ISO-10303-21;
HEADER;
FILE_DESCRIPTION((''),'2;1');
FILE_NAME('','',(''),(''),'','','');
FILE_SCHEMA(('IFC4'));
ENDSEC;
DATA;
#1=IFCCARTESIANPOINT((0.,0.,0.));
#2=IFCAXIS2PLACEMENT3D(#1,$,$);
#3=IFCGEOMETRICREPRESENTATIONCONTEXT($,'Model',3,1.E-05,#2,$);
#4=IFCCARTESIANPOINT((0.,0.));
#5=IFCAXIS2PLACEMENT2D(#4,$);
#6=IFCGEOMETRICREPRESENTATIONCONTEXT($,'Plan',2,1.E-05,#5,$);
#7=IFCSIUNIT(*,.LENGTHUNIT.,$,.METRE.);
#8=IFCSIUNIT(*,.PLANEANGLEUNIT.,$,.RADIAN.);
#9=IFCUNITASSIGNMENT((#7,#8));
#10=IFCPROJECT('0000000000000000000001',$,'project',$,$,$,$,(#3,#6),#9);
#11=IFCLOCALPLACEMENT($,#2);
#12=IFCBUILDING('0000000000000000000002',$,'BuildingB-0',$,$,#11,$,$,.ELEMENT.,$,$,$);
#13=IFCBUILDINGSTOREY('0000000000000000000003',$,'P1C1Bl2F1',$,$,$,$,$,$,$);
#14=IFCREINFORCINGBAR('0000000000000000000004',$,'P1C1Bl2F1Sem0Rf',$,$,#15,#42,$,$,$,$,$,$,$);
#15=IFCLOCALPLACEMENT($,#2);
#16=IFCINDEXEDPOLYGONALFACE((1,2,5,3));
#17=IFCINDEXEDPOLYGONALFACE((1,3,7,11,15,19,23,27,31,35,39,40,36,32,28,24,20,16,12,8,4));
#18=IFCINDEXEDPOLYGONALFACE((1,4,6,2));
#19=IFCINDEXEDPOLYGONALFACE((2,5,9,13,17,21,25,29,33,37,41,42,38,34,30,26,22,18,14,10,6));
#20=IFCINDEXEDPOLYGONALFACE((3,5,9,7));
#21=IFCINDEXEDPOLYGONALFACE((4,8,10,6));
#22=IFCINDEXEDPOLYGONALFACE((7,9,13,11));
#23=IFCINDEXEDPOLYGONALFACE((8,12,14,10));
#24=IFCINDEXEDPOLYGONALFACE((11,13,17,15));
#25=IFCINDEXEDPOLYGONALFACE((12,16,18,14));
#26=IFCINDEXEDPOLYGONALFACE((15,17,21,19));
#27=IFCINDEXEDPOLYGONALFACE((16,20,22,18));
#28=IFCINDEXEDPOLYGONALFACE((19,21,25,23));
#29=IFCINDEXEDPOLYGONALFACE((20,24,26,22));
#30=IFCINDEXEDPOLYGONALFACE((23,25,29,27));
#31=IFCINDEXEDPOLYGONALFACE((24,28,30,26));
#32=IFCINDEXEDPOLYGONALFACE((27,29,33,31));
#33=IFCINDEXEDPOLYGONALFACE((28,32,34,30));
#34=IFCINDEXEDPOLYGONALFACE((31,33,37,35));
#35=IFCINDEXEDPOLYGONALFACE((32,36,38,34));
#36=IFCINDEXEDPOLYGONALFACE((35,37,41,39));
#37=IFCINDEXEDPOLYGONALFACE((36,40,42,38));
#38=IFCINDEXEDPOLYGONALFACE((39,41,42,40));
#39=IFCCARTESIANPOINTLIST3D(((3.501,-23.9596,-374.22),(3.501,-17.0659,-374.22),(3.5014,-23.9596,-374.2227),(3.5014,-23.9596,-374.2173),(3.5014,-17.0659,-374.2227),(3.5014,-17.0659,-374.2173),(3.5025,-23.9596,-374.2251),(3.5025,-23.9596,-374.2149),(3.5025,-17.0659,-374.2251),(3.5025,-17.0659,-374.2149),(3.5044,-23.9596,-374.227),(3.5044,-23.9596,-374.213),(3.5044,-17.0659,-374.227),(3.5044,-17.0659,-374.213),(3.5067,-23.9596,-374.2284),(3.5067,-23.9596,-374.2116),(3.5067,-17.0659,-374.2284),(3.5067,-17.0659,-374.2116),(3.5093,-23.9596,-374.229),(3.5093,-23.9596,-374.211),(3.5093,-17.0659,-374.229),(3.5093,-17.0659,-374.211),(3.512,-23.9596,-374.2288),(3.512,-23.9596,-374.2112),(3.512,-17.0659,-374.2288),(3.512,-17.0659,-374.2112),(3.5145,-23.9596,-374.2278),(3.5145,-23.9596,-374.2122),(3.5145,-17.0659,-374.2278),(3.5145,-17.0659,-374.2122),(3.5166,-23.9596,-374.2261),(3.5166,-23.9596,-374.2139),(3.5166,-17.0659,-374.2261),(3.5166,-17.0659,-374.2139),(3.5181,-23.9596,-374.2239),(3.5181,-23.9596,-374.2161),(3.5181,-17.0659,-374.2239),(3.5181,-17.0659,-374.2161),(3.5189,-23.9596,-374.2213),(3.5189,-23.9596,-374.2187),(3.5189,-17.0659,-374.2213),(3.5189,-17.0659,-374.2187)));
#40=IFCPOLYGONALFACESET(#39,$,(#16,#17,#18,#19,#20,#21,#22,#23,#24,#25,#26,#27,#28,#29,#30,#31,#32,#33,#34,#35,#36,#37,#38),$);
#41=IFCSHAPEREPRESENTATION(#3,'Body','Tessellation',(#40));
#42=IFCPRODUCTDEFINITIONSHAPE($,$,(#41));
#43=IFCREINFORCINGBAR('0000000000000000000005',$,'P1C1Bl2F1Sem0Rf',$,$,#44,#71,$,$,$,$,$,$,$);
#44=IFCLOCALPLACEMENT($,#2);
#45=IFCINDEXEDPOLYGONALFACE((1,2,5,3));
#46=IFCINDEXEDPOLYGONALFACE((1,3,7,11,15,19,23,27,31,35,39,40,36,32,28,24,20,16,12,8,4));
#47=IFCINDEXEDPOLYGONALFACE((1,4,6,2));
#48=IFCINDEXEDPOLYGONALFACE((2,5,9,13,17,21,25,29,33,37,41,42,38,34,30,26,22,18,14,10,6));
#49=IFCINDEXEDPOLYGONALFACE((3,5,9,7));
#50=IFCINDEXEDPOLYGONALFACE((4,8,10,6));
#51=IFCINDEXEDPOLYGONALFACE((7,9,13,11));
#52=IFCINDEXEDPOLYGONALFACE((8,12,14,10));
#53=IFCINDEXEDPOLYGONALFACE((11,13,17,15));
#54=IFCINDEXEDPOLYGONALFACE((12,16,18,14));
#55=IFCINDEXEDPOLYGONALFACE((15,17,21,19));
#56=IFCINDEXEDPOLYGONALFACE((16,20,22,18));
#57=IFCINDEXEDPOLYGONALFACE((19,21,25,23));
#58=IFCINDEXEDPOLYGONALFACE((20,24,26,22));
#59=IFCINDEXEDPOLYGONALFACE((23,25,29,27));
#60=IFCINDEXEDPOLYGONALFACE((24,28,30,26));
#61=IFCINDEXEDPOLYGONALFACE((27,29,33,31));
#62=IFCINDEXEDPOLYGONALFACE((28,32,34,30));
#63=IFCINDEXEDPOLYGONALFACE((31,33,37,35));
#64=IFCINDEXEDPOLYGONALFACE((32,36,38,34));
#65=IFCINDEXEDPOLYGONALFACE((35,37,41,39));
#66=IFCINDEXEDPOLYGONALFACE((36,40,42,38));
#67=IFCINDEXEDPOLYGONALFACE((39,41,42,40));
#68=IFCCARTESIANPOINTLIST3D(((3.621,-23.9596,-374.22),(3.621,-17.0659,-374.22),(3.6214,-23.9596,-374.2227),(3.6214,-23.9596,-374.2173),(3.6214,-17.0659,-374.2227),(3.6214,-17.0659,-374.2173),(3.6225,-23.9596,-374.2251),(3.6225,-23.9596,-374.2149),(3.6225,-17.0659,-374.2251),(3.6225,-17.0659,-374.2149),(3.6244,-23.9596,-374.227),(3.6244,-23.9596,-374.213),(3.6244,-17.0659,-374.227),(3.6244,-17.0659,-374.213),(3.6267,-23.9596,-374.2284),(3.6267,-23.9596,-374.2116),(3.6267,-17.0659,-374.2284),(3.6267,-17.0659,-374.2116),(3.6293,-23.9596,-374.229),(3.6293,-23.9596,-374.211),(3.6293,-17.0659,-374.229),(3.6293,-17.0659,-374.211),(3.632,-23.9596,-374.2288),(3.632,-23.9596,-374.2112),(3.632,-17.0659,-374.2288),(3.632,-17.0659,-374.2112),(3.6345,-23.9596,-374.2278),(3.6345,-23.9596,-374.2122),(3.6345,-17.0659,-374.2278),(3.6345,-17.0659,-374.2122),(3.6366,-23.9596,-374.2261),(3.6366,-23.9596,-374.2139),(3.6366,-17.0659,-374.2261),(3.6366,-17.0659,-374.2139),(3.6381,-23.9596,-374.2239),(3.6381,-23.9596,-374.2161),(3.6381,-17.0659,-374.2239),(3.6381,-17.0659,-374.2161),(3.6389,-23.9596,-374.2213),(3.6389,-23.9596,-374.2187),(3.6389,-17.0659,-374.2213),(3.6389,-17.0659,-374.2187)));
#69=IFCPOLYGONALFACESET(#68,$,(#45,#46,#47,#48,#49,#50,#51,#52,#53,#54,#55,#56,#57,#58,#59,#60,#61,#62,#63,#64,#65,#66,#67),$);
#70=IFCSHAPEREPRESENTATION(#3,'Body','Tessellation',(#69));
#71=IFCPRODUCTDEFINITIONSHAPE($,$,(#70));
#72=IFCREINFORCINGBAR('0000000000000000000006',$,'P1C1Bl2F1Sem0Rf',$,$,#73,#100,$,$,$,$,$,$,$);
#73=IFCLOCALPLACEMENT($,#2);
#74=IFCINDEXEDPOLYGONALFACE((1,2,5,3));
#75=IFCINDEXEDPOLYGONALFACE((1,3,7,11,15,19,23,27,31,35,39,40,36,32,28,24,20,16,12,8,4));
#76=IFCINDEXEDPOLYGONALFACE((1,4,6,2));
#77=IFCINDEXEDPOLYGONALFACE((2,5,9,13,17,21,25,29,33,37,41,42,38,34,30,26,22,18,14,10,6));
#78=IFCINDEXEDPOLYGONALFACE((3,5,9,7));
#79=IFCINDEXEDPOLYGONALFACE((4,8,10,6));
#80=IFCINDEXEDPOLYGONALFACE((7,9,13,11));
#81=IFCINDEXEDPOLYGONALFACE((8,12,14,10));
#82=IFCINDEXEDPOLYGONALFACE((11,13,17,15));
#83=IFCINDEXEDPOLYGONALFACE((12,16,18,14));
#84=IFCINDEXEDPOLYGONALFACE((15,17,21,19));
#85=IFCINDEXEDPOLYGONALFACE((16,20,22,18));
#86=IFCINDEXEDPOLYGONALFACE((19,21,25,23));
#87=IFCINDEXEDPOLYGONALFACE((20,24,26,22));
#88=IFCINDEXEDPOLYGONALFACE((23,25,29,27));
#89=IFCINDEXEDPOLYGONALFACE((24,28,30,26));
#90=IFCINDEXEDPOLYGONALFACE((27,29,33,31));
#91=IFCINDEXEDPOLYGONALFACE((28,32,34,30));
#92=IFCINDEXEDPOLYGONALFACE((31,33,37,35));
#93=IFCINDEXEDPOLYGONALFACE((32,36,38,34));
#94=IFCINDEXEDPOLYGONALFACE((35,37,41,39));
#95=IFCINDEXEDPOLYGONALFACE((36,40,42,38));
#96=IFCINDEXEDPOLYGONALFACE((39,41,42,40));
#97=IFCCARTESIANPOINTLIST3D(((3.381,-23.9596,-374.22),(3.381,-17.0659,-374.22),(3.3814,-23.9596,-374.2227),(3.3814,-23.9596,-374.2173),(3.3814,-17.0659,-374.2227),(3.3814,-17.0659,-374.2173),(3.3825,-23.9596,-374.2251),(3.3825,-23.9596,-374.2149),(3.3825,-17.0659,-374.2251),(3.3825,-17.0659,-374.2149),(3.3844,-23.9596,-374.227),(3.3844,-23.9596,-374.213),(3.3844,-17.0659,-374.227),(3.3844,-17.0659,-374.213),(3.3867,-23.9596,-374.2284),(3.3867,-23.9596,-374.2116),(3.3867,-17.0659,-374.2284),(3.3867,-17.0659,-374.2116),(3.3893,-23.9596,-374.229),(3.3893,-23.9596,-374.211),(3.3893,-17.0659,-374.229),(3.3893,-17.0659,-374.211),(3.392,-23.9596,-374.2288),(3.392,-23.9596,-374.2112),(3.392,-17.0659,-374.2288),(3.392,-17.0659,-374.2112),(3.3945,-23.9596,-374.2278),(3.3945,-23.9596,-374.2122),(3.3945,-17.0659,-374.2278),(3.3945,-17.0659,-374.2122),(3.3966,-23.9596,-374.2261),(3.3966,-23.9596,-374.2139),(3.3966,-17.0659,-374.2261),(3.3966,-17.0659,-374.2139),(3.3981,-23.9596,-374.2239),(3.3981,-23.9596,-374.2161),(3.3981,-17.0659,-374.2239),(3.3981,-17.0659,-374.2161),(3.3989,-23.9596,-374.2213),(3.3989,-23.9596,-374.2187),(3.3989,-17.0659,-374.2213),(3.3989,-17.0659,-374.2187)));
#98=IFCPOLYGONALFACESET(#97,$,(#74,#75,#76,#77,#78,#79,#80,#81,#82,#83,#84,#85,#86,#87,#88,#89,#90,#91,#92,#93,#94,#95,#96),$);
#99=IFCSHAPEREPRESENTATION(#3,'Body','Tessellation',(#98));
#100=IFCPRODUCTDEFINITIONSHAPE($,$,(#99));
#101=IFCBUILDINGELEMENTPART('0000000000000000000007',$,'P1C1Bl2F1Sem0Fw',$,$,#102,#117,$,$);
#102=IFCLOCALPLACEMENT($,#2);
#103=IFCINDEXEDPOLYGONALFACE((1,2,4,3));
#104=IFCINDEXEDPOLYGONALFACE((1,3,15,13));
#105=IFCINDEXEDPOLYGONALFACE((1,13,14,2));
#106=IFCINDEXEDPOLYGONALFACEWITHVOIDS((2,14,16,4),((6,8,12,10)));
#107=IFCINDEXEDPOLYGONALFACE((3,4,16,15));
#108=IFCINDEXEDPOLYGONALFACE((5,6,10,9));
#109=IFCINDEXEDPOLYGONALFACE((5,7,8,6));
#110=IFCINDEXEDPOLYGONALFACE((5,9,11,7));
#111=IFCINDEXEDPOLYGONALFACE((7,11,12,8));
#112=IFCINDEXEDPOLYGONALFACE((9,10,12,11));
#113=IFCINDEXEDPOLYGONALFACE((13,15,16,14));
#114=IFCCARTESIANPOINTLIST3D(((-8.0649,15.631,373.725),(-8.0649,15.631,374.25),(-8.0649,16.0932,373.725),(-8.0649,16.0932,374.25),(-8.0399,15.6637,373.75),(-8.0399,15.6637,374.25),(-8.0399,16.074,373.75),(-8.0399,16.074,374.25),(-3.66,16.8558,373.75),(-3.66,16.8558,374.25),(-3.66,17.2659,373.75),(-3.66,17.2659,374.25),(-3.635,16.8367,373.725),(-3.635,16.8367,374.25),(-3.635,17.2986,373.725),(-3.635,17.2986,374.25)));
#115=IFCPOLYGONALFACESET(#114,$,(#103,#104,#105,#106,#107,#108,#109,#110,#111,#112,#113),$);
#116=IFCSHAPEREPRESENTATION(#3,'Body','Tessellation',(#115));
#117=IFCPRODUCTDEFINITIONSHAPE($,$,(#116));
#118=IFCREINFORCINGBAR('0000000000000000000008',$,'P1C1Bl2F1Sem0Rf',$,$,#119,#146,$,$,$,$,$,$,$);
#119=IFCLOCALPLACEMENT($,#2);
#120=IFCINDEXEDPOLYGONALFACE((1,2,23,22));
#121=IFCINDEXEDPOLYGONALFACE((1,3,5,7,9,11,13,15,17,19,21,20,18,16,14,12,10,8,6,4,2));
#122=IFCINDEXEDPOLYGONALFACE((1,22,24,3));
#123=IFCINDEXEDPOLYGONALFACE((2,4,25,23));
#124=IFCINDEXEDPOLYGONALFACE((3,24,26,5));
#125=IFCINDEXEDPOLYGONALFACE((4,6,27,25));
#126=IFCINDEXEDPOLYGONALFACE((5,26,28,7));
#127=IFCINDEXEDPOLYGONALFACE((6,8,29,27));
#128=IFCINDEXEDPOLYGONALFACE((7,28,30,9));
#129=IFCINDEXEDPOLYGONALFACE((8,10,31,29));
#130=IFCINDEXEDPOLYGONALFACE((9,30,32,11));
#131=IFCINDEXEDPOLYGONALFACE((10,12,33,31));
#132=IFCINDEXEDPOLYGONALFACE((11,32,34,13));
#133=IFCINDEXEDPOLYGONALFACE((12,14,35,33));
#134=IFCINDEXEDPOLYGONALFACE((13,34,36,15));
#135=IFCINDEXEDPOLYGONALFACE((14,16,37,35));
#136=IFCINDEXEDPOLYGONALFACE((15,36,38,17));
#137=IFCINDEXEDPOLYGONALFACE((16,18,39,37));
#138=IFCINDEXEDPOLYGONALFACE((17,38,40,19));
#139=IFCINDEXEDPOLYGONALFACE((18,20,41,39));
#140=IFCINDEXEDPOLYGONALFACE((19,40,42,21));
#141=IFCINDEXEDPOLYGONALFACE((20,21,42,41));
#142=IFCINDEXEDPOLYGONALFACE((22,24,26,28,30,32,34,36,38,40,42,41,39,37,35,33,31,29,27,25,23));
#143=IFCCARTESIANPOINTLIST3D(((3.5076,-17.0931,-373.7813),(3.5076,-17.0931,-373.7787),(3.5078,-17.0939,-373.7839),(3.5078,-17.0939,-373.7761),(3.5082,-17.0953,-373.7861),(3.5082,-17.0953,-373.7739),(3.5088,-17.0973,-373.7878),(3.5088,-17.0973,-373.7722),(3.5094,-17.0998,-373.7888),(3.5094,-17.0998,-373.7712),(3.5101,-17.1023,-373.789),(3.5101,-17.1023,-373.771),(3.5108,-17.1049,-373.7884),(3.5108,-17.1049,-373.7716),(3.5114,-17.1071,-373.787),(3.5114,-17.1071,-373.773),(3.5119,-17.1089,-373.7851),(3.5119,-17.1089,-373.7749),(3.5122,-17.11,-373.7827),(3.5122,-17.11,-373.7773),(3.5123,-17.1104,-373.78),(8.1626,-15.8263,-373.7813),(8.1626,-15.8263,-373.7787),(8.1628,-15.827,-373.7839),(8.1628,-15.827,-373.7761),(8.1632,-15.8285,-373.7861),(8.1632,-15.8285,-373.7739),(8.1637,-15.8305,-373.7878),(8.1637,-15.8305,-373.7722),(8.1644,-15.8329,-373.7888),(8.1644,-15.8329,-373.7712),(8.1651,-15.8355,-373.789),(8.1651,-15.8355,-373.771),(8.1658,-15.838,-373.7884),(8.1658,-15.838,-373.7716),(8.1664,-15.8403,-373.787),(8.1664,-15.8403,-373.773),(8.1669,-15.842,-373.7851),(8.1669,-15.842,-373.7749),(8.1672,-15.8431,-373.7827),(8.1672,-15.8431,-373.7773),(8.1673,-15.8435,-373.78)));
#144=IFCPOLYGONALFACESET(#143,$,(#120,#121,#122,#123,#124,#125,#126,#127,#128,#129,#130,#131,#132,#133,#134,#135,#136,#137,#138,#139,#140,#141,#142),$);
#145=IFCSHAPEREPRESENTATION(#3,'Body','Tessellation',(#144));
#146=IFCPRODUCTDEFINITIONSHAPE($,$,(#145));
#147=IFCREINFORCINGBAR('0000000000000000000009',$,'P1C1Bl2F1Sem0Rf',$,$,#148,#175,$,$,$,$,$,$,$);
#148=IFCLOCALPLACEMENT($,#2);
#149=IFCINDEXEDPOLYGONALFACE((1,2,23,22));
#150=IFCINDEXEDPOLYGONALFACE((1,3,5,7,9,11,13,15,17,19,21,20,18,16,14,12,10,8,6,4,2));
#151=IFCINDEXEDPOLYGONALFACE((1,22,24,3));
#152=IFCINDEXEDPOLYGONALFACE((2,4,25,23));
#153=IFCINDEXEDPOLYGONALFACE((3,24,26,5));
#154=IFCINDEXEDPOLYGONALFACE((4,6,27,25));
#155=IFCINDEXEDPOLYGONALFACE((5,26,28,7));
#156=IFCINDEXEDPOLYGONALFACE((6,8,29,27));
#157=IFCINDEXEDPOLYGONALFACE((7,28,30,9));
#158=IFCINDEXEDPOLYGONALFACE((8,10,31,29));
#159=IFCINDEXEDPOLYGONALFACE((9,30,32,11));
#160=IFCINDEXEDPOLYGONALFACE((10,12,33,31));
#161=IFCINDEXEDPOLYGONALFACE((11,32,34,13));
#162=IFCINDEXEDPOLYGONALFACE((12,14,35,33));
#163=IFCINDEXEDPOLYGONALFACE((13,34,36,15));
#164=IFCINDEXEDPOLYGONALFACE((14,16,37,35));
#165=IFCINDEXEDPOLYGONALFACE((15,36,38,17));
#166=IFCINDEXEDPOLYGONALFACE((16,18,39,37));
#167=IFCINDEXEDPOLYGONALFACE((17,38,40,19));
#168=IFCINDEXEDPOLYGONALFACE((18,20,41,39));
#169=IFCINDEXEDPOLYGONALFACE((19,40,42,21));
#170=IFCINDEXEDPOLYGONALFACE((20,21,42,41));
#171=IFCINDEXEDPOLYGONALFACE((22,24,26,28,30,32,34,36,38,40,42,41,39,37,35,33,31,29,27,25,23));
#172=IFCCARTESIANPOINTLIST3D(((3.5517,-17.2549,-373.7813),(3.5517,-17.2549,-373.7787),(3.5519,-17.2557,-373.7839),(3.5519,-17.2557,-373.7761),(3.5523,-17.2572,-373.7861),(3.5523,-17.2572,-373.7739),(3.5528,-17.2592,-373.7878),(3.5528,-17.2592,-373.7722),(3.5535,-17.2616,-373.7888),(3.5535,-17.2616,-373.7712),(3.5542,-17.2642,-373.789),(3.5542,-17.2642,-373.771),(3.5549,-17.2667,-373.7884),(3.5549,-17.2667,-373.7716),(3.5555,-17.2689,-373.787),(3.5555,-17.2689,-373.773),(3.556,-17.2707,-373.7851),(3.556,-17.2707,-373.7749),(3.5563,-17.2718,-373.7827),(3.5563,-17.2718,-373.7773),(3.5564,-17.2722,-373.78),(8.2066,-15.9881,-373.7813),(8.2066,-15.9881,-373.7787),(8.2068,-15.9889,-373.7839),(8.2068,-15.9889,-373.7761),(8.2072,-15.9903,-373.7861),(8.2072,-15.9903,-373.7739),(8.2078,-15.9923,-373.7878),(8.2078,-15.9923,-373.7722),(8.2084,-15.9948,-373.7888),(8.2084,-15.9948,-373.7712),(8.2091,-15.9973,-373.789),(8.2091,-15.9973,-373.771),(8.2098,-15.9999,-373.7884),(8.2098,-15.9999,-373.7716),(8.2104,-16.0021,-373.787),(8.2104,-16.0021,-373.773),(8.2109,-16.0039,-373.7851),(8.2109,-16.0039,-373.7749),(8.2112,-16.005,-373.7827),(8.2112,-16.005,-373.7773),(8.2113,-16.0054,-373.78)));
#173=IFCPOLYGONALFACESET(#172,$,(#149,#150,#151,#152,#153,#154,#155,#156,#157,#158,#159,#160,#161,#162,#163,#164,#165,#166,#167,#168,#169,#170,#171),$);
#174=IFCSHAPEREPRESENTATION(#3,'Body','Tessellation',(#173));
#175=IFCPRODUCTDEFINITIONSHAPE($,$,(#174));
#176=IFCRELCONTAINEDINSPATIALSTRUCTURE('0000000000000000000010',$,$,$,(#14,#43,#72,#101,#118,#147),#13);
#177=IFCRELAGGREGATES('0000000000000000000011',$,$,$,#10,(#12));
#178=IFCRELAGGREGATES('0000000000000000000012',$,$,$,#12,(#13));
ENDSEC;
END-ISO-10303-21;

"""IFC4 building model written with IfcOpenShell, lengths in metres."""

from ifc_helpers import new_model, entity, si_unit, origin, origin_2d, place, context, project, spatial, polyline, outline, extrude, element, save


model = new_model("IFC4")

# Units and contexts
model_context = context("Model", 3, precision=1e-05, world=origin())
plan_context = context("Plan", 2, precision=1e-05, world=origin_2d())
ifc_project = project(units=[si_unit("LENGTHUNIT", "METRE"), si_unit("PLANEANGLEUNIT", "RADIAN")], contexts=[model_context, plan_context])

# Building, storey
building_placement = place(None, origin())
building = spatial("IfcBuilding", under=ifc_project, at=building_placement, Name="BuildingB-0", CompositionType="ELEMENT")
storey = spatial("IfcBuildingStorey", under=building, Name="P1C1Bl2F1")

# Reinforcing bars
element("IfcReinforcingBar", 1, inside=storey, Name="P1C1Bl2F1Sem0Rf", context=model_context, shape_type="SweptSolid", body=[
    entity("IfcSurfaceCurveSweptAreaSolid", entity("IfcCircleProfileDef", "AREA", None, None, 0.009), None, entity("IfcPolyline", [entity("IfcCartesianPoint", [-3.51, 23.9596, 374.22]), entity("IfcCartesianPoint", [-3.51, 17.0659, 374.22])]), None, None, entity("IfcPlane", entity("IfcAxis2Placement3D", entity("IfcCartesianPoint", [-3.51, 23.9596, 374.22]), entity("IfcDirection", [0.0, 0.0, 1.0]), entity("IfcDirection", [1.0, 0.0, 0.0])))),
])
element("IfcReinforcingBar", 2, inside=storey, Name="P1C1Bl2F1Sem0Rf", context=model_context, shape_type="SweptSolid", body=[
    entity("IfcSurfaceCurveSweptAreaSolid", entity("IfcCircleProfileDef", "AREA", None, None, 0.009), None, entity("IfcPolyline", [entity("IfcCartesianPoint", [-3.63, 23.9596, 374.22]), entity("IfcCartesianPoint", [-3.63, 17.0659, 374.22])]), None, None, entity("IfcPlane", entity("IfcAxis2Placement3D", entity("IfcCartesianPoint", [-3.63, 23.9596, 374.22]), entity("IfcDirection", [0.0, 0.0, 1.0]), entity("IfcDirection", [1.0, 0.0, 0.0])))),
])
element("IfcReinforcingBar", 3, inside=storey, Name="P1C1Bl2F1Sem0Rf", context=model_context, shape_type="SweptSolid", body=[
    entity("IfcSurfaceCurveSweptAreaSolid", entity("IfcCircleProfileDef", "AREA", None, None, 0.009), None, entity("IfcPolyline", [entity("IfcCartesianPoint", [-3.39, 23.9596, 374.22]), entity("IfcCartesianPoint", [-3.39, 17.0659, 374.22])]), None, None, entity("IfcPlane", entity("IfcAxis2Placement3D", entity("IfcCartesianPoint", [-3.39, 23.9596, 374.22]), entity("IfcDirection", [0.0, 0.0, 1.0]), entity("IfcDirection", [1.0, 0.0, 0.0])))),
])

# Building element part, opening
building_element_part_1 = element("IfcBuildingElementPart", 4, inside=storey, Name="P1C1Bl2F1Sem0Fw", context=model_context, shape_type="SweptSolid", body=[
    extrude(outline(polyline([(-8.0649, 15.631, 373.725), (-8.0649, 16.0932, 373.725), (-3.635, 17.2986, 373.725), (-3.635, 16.8367, 373.725), (-8.0649, 15.631, 373.725)])), None, (0.0, 0.0, 1.0), 0.525),
])
element("IfcOpeningElement", 5, inside=storey, cuts=building_element_part_1, context=model_context, shape_type="SweptSolid", body=[
    extrude(outline(polyline([(-8.0399, 15.6637, 373.75), (-8.0399, 16.074, 373.75), (-3.66, 17.2659, 373.75), (-3.66, 16.8558, 373.75), (-8.0399, 15.6637, 373.75)])), None, (0.0, 0.0, 1.0), 0.5),
])

# Reinforcing bars
element("IfcReinforcingBar", 6, inside=storey, Name="P1C1Bl2F1Sem0Rf", context=model_context, shape_type="SweptSolid", body=[
    entity("IfcSurfaceCurveSweptAreaSolid", entity("IfcCircleProfileDef", "AREA", None, None, 0.009), None, entity("IfcPolyline", [entity("IfcCartesianPoint", [-3.51, 17.1017, 373.78]), entity("IfcCartesianPoint", [-8.1649, 15.8348, 373.78])]), None, None, entity("IfcPlane", entity("IfcAxis2Placement3D", entity("IfcCartesianPoint", [-3.51, 17.1017, 373.78]), entity("IfcDirection", [0.0, 0.0, 1.0]), entity("IfcDirection", [1.0, 0.0, 0.0])))),
])
element("IfcReinforcingBar", 7, inside=storey, Name="P1C1Bl2F1Sem0Rf", context=model_context, shape_type="SweptSolid", body=[
    entity("IfcSurfaceCurveSweptAreaSolid", entity("IfcCircleProfileDef", "AREA", None, None, 0.009), None, entity("IfcPolyline", [entity("IfcCartesianPoint", [-3.554, 17.2635, 373.78]), entity("IfcCartesianPoint", [-8.209, 15.9967, 373.78])]), None, None, entity("IfcPlane", entity("IfcAxis2Placement3D", entity("IfcCartesianPoint", [-3.554, 17.2635, 373.78]), entity("IfcDirection", [0.0, 0.0, 1.0]), entity("IfcDirection", [1.0, 0.0, 0.0])))),
])

save(model, "model.ifc")
